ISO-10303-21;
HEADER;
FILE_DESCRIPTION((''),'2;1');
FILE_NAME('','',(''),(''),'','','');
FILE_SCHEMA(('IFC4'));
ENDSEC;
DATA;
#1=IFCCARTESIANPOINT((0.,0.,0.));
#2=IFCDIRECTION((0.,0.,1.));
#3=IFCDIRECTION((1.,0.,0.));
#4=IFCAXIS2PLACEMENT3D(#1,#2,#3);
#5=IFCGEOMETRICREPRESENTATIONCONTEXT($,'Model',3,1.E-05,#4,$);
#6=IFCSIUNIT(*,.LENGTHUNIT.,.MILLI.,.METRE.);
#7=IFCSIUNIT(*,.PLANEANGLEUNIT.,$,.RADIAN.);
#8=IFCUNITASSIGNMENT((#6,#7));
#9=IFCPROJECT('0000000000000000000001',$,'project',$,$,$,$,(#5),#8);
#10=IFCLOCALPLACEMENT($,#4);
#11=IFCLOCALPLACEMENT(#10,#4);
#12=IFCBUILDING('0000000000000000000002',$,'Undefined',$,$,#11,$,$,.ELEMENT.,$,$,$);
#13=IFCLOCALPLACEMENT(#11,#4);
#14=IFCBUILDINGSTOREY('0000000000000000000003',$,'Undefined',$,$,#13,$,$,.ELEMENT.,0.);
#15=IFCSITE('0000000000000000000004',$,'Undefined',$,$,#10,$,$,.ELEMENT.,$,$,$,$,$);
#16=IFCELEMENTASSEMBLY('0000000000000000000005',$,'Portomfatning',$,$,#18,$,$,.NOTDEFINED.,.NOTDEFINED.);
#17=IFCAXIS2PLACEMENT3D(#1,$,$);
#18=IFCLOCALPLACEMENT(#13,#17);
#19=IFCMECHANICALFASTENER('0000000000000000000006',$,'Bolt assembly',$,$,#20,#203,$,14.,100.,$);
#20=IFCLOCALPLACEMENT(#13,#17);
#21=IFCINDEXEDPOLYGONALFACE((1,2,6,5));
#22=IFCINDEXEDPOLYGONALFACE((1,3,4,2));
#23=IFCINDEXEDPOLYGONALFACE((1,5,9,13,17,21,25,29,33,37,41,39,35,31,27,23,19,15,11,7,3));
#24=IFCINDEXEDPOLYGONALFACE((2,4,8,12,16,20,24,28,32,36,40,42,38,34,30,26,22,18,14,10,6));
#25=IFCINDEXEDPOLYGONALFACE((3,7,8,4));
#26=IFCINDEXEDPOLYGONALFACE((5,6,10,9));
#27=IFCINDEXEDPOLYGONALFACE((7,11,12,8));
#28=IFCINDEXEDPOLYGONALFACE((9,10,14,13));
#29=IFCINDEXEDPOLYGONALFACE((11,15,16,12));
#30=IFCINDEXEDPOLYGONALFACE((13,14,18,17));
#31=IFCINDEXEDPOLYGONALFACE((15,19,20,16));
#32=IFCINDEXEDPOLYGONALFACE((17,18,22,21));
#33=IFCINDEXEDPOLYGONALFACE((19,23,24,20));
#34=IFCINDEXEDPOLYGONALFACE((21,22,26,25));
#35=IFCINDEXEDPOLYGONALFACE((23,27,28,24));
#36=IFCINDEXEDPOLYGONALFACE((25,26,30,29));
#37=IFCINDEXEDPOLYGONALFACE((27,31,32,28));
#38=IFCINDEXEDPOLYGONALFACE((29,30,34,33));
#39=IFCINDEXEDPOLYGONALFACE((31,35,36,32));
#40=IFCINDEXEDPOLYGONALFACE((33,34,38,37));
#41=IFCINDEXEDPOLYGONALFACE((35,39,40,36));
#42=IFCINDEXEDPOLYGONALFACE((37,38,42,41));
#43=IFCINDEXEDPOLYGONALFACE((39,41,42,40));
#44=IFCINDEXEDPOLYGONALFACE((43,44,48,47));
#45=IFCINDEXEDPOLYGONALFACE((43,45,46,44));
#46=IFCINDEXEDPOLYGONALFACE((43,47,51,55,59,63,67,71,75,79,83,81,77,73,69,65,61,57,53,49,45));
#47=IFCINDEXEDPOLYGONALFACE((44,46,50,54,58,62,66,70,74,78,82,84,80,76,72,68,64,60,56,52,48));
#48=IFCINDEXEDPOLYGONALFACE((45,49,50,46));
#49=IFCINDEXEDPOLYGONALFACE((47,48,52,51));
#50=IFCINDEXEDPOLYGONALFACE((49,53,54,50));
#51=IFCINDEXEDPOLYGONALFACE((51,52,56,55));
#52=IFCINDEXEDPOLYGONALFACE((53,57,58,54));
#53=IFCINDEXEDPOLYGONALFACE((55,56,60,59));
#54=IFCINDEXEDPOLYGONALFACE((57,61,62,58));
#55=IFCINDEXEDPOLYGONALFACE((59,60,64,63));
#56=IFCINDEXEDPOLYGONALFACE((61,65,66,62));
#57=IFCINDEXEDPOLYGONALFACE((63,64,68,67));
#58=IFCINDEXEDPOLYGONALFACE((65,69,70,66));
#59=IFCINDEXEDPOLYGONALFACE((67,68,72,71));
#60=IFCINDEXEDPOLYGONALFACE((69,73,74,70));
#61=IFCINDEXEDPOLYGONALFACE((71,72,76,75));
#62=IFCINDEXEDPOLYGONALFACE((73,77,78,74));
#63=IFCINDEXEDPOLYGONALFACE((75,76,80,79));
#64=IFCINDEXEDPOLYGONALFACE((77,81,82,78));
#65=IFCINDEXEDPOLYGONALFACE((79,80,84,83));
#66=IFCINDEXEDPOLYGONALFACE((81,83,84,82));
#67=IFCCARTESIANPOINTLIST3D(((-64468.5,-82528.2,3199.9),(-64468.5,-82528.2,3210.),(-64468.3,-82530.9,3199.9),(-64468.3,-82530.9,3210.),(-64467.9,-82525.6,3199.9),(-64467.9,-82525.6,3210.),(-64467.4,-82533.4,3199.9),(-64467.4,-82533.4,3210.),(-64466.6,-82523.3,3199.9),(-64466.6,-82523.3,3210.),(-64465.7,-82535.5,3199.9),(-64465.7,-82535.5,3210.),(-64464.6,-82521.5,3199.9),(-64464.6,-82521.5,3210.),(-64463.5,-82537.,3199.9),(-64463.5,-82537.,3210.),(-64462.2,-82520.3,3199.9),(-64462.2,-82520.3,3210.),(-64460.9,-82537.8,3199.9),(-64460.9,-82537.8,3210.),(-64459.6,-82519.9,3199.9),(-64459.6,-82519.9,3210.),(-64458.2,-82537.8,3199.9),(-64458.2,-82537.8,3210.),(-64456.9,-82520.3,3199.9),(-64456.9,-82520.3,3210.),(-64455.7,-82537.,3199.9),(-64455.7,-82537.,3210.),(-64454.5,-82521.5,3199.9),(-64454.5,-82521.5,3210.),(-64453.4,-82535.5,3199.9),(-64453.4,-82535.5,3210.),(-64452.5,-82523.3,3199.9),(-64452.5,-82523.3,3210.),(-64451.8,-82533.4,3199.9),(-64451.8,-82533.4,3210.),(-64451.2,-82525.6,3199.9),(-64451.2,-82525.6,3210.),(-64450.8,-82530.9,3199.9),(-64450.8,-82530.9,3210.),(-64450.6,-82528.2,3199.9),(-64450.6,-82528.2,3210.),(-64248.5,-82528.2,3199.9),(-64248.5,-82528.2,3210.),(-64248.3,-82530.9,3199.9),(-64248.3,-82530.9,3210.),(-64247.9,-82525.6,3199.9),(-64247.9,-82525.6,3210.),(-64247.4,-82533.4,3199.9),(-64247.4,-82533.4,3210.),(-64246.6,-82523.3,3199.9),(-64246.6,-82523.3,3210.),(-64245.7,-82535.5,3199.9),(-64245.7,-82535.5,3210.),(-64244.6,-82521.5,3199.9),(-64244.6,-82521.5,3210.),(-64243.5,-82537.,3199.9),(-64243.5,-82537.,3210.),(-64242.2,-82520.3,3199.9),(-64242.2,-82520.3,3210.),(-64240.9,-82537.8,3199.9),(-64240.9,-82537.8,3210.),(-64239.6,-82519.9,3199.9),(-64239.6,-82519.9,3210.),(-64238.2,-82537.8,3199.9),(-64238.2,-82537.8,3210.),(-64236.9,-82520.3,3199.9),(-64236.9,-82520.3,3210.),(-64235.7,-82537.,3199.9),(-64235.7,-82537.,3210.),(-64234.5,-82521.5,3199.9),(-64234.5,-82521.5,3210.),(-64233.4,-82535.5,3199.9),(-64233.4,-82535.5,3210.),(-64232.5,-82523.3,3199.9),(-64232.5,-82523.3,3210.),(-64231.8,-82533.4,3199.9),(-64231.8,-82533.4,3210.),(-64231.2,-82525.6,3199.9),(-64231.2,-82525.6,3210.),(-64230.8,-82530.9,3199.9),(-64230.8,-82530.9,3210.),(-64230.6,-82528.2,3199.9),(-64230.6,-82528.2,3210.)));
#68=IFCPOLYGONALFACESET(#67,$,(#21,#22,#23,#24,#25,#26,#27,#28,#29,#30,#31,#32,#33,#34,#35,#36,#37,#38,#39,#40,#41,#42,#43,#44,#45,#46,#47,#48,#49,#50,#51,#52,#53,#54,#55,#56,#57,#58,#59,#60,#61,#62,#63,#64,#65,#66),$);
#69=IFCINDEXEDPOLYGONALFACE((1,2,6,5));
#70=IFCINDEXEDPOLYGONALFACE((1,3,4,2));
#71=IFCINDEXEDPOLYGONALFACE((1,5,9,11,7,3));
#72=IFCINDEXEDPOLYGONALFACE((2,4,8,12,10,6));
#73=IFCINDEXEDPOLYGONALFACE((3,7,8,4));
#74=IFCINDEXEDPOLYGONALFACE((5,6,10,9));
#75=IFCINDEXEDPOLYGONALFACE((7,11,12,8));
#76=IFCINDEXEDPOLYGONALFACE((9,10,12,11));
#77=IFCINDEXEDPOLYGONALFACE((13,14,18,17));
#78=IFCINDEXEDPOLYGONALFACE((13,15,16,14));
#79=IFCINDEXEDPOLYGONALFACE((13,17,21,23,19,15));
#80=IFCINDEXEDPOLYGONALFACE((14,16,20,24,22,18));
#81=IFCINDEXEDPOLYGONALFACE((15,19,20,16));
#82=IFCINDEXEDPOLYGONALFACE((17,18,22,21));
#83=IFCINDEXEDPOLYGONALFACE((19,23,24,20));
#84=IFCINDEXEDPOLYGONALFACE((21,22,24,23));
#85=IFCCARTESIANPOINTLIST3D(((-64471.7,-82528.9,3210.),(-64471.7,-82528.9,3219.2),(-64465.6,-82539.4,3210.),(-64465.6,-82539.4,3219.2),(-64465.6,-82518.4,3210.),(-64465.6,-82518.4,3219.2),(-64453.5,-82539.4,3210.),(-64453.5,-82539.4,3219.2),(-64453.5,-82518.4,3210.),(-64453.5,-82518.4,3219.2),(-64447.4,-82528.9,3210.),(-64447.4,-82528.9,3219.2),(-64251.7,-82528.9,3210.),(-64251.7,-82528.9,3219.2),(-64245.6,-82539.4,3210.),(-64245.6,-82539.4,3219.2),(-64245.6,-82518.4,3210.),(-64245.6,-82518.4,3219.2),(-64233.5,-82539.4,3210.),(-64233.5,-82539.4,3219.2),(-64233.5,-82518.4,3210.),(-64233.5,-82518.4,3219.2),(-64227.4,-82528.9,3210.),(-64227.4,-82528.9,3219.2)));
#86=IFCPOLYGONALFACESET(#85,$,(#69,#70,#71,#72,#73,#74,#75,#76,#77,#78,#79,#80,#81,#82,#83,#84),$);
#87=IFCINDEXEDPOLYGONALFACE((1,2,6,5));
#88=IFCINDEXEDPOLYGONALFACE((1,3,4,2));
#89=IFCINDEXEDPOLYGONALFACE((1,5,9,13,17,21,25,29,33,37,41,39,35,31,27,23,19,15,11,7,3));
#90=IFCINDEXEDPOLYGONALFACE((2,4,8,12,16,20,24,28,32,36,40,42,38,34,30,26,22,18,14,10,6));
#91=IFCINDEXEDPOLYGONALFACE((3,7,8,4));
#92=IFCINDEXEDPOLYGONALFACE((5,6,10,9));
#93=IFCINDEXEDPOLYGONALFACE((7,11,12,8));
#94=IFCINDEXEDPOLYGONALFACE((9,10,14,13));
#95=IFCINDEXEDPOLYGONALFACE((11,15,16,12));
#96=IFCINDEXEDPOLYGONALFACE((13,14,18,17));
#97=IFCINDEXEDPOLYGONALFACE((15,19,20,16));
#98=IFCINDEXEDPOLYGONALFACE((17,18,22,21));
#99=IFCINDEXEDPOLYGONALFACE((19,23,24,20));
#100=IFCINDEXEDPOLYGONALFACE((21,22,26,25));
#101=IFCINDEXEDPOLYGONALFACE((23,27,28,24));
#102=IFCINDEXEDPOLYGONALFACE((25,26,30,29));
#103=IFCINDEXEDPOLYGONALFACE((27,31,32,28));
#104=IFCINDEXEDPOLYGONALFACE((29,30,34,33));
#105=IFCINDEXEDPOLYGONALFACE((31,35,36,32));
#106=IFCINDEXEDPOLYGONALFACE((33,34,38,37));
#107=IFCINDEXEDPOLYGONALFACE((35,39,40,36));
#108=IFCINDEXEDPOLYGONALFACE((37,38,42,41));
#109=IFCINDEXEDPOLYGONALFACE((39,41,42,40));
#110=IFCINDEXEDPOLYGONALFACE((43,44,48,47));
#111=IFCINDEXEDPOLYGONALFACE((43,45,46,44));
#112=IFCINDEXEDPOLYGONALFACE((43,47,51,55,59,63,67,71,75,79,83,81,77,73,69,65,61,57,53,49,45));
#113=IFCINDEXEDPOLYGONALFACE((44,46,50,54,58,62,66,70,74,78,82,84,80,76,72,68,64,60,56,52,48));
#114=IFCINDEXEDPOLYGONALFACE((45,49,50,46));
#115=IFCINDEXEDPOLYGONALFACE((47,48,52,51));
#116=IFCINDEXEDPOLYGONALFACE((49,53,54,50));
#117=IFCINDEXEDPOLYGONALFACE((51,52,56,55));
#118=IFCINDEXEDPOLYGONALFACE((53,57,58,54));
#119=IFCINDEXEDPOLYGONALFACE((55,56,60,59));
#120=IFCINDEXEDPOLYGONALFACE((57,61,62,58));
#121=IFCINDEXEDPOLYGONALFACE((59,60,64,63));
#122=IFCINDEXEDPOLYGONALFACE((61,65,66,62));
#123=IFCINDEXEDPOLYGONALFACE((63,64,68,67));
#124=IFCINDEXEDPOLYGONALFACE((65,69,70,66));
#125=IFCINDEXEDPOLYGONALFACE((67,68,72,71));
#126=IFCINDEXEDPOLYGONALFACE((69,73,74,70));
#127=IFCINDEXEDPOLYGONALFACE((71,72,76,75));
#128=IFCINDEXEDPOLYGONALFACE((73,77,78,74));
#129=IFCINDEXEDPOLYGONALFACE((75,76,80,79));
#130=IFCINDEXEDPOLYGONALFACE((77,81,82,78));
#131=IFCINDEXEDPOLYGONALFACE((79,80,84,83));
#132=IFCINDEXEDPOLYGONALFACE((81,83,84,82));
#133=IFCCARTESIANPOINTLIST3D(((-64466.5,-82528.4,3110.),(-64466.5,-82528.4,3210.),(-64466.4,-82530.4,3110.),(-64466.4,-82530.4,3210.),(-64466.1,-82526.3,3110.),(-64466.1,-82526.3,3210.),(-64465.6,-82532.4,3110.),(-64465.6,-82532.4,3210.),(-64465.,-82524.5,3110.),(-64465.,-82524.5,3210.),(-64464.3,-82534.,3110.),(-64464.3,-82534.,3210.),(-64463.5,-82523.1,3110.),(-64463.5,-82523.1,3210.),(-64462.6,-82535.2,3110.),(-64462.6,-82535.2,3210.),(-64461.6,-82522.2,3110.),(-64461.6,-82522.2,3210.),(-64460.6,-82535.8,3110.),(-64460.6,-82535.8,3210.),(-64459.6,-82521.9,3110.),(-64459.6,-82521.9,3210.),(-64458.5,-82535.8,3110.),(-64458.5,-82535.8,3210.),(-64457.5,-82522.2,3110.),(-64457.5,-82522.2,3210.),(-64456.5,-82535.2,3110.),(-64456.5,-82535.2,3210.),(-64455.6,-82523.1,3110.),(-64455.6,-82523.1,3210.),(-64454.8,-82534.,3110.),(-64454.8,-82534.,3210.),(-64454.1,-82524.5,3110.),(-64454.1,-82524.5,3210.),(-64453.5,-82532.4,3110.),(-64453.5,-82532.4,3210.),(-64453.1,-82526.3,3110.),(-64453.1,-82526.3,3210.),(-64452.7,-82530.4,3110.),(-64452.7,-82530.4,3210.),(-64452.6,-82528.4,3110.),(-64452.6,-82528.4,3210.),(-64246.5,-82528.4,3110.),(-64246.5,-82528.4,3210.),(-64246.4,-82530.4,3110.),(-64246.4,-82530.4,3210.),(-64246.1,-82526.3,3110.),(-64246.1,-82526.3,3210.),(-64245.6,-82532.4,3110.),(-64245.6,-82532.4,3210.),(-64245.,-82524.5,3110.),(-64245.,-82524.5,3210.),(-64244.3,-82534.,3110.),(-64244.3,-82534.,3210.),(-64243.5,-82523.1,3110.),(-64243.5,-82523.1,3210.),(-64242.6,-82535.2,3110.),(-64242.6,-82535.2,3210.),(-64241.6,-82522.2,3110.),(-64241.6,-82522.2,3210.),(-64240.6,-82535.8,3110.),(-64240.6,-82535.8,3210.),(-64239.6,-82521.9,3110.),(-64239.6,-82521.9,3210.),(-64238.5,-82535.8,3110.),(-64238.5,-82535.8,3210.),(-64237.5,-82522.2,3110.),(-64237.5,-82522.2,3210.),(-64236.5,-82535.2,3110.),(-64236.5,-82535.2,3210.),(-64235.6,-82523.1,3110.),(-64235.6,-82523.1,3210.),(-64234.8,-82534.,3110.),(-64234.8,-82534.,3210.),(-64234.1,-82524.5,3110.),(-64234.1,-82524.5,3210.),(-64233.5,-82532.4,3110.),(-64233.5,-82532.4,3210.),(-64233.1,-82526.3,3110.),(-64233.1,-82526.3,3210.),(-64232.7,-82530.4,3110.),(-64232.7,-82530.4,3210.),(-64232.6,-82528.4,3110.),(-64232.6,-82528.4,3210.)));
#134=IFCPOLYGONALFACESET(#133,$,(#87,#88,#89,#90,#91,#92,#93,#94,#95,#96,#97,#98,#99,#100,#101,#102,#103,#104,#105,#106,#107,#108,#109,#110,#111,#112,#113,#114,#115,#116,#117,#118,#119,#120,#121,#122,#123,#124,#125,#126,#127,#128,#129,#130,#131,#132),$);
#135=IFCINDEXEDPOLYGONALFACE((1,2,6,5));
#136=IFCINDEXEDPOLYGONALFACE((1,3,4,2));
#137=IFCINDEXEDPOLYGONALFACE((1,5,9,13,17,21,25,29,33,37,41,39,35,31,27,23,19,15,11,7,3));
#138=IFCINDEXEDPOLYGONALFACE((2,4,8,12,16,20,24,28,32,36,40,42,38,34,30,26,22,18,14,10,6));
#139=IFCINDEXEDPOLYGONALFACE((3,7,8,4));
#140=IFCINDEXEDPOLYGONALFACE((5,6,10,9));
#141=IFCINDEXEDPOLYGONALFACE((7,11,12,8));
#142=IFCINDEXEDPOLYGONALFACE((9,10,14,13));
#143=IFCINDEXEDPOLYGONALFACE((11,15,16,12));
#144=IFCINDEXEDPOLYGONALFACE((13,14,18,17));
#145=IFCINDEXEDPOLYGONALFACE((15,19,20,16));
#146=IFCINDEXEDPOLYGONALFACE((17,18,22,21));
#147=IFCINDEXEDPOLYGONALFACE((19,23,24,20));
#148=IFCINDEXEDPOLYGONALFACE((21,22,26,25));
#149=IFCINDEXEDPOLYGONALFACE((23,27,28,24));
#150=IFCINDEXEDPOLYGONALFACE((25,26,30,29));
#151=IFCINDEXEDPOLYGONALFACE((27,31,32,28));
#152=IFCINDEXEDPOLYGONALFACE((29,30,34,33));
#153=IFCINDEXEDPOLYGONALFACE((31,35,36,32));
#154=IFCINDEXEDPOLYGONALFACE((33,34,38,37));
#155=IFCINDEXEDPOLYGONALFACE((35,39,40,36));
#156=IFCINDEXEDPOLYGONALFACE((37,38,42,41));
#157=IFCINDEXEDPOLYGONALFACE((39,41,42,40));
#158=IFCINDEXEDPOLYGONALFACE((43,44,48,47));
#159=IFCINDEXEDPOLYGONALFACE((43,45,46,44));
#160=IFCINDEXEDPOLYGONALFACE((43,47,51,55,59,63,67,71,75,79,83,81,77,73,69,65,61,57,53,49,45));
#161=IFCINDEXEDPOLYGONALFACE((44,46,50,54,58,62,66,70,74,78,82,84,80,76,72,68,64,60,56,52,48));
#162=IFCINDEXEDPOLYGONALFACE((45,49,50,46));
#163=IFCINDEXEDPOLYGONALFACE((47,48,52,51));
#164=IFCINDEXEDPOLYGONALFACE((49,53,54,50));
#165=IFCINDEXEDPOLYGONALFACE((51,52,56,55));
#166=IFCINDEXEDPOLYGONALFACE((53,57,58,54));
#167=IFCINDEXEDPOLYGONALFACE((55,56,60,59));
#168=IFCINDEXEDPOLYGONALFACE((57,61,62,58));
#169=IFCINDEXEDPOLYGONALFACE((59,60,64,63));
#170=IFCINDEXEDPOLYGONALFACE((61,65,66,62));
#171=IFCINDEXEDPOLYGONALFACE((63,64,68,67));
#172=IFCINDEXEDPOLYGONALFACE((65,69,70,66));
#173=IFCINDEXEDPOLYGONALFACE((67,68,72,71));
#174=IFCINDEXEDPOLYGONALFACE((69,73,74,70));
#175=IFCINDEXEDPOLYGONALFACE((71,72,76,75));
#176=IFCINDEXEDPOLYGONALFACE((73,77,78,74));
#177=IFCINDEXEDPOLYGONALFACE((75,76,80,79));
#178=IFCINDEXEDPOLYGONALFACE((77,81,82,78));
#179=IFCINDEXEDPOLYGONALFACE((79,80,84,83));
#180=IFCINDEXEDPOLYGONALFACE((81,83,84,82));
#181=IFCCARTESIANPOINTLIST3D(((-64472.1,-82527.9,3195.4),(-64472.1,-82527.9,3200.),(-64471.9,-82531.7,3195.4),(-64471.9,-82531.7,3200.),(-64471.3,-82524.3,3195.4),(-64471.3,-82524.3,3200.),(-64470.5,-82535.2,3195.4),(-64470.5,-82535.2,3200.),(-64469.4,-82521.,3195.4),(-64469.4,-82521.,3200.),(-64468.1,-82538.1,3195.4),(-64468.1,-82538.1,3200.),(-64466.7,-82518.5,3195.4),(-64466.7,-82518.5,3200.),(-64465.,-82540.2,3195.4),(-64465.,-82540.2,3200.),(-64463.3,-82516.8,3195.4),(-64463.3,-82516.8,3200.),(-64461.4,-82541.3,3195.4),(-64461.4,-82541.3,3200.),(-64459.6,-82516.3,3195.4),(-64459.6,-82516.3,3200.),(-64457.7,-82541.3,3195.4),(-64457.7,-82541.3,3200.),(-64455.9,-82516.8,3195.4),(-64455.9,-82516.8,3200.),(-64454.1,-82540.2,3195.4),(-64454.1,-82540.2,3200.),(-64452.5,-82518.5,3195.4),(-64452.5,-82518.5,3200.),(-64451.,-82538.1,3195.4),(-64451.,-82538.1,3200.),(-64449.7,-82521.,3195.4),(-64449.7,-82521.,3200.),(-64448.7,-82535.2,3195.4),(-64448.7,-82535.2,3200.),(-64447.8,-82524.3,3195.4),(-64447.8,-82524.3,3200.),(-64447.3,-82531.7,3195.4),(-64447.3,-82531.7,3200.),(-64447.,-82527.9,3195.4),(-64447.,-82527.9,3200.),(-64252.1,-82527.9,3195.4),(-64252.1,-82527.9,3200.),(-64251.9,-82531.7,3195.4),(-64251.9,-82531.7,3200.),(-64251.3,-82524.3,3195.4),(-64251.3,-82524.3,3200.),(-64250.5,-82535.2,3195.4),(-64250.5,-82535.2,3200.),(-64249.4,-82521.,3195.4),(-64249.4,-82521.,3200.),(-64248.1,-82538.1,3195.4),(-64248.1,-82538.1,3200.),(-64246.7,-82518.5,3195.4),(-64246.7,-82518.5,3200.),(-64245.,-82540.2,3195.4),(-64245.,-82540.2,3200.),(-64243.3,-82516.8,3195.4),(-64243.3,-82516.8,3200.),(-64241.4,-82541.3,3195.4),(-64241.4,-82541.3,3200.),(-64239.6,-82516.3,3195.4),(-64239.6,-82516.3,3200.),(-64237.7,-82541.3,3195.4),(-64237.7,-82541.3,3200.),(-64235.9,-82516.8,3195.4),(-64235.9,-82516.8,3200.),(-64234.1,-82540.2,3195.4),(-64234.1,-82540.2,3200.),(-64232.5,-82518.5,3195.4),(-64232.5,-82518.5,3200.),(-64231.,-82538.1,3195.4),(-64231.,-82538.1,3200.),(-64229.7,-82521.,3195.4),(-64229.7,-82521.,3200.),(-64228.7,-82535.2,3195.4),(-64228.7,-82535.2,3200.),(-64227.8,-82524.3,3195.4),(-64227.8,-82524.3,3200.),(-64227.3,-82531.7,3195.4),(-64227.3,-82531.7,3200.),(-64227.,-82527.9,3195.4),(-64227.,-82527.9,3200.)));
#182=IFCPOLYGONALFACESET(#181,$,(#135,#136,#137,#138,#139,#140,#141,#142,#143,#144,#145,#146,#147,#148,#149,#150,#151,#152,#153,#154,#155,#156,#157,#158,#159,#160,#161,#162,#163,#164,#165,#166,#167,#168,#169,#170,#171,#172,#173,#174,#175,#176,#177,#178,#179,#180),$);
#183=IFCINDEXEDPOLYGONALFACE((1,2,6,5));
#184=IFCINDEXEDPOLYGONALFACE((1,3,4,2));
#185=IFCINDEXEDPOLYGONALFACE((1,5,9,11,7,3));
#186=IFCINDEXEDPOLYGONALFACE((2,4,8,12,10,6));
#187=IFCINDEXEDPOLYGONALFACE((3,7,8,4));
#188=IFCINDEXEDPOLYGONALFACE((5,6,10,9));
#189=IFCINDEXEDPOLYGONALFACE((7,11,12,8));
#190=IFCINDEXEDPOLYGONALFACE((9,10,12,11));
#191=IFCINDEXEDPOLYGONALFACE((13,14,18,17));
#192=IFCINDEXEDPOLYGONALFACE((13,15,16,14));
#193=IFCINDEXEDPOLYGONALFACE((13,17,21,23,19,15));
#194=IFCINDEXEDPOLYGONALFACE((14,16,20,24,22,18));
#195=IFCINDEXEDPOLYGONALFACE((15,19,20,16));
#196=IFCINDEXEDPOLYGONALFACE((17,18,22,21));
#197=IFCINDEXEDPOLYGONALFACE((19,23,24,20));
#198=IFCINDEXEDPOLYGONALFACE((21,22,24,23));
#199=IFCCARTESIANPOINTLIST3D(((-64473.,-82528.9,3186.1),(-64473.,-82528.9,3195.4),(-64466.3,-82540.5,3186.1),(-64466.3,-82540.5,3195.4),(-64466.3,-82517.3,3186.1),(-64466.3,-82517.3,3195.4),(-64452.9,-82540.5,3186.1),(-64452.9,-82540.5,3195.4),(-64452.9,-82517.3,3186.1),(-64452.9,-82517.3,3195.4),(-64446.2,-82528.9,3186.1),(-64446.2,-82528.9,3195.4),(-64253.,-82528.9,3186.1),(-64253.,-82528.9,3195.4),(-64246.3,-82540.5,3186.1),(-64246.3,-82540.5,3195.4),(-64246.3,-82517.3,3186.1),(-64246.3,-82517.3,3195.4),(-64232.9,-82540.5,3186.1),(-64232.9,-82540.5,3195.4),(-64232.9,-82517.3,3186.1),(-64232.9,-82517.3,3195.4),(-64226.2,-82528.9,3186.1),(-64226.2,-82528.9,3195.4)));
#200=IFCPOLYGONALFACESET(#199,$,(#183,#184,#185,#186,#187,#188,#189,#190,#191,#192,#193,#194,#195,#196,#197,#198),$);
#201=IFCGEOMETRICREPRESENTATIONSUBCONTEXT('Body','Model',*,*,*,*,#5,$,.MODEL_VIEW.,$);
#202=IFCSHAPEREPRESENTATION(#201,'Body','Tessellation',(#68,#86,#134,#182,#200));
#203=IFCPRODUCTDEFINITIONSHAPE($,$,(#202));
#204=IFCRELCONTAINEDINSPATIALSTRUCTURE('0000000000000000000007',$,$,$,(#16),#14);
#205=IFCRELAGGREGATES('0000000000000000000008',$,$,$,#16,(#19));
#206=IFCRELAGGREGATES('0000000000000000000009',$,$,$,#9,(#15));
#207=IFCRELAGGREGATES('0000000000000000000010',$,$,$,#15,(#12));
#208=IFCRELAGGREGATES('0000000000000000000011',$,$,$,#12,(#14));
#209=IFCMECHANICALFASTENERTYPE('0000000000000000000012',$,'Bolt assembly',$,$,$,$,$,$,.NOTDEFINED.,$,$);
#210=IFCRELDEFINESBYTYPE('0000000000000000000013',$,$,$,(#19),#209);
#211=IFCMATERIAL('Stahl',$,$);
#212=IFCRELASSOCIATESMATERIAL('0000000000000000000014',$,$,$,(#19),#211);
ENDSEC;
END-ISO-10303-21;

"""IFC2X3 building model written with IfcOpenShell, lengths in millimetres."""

from ifc_helpers import new_model, si_unit, frame, origin_with_axes, origin_2d_with_axis, place, context, subcontext, project, spatial, polyline, circle, outline, extrude, source, transform, mapped, material, type_object, element, aggregate, save


model = new_model("IFC2X3")

# Units and contexts
model_context = context("Model", 3, precision=1e-05, world=origin_with_axes())
body_context = subcontext(model_context, "Body", "Model", "MODEL_VIEW")
ifc_project = project(units=[si_unit("LENGTHUNIT", "METRE", prefix="MILLI"), si_unit("PLANEANGLEUNIT", "RADIAN")], contexts=[model_context])

# Site, building, storey
site_placement = place(None, origin_with_axes())
site = spatial("IfcSite", under=ifc_project, at=site_placement, Name="Undefined", CompositionType="ELEMENT")
building_placement = place(site_placement, origin_with_axes())
building = spatial("IfcBuilding", under=site, at=building_placement, Name="Undefined", CompositionType="ELEMENT")
storey_placement = place(building_placement, origin_with_axes())
storey = spatial("IfcBuildingStorey", under=building, at=storey_placement, Name="Undefined", CompositionType="ELEMENT", Elevation=0.0)

# Element assembly
assembly_1_placement = place(storey_placement, origin_with_axes())
assembly_1 = element("IfcElementAssembly", 1, at=assembly_1_placement, inside=storey, Name="Portomfatning", AssemblyPlace="NOTDEFINED", PredefinedType="NOTDEFINED")

# Mechanical fastener
mechanical_fastener_type = type_object("IfcMechanicalFastenerType", Name="Bolt assembly")
ifc_material_1 = material(Name="Stahl")
shared_shape_1 = source(origin_with_axes(), body_context, "Body", "SweptSolid", [
    extrude(circle(Radius=9.0, at=origin_2d_with_axis()), frame((0.0, 0.0, 0.0), z_axis=(0.0, 1.0, 0.0), x_axis=(1.0, 0.0, 0.0)), (0.0, 0.0, 1.0), 10.1),
    extrude(outline(polyline([(10.5, -6.1), (10.5, 6.1), (0.0, 12.1), (-10.5, 6.1), (-10.5, -6.1), (0.0, -12.1), (10.5, -6.1)])), frame((0.0, -9.2, 0.0), z_axis=(0.0, 1.0, 0.0), x_axis=(1.0, 0.0, 0.0)), (0.0, 0.0, 1.0), 9.2),
    extrude(circle(Radius=7.0, at=origin_2d_with_axis()), frame((0.0, 0.0, 0.0), z_axis=(0.0, 1.0, 0.0), x_axis=(1.0, 0.0, 0.0)), (0.0, 0.0, 1.0), 100.0),
    extrude(circle(Radius=12.6, at=origin_2d_with_axis()), frame((0.0, 10.0, 0.0), z_axis=(0.0, 1.0, 0.0), x_axis=(1.0, 0.0, 0.0)), (0.0, 0.0, 1.0), 4.6),
    extrude(outline(polyline([(11.6, -6.7), (11.6, 6.7), (0.0, 13.4), (-11.6, 6.7), (-11.6, -6.7), (0.0, -13.4), (11.6, -6.7)])), frame((0.0, 14.6, 0.0), z_axis=(0.0, 1.0, 0.0), x_axis=(1.0, 0.0, 0.0)), (0.0, 0.0, 1.0), 9.2),
])
mechanical_fastener_1_placement = place(assembly_1_placement, frame((-64349.6, -82528.9, 3210.0), z_axis=(-1.0, 0.0, 0.0), x_axis=(0.0, 1.0, 0.0)))
mechanical_fastener_1 = element("IfcMechanicalFastener", 2, at=mechanical_fastener_1_placement, type_object=mechanical_fastener_type, material=ifc_material_1, Name="Bolt assembly", NominalDiameter=14.0, NominalLength=100.0, context=body_context, shape_type="MappedRepresentation", body=[
    mapped(shared_shape_1, transform((0.0, 0.0, -110.0))),
    mapped(shared_shape_1, transform((0.0, 0.0, 110.0))),
])

aggregate(assembly_1, [mechanical_fastener_1])

save(model, "model.ifc")
